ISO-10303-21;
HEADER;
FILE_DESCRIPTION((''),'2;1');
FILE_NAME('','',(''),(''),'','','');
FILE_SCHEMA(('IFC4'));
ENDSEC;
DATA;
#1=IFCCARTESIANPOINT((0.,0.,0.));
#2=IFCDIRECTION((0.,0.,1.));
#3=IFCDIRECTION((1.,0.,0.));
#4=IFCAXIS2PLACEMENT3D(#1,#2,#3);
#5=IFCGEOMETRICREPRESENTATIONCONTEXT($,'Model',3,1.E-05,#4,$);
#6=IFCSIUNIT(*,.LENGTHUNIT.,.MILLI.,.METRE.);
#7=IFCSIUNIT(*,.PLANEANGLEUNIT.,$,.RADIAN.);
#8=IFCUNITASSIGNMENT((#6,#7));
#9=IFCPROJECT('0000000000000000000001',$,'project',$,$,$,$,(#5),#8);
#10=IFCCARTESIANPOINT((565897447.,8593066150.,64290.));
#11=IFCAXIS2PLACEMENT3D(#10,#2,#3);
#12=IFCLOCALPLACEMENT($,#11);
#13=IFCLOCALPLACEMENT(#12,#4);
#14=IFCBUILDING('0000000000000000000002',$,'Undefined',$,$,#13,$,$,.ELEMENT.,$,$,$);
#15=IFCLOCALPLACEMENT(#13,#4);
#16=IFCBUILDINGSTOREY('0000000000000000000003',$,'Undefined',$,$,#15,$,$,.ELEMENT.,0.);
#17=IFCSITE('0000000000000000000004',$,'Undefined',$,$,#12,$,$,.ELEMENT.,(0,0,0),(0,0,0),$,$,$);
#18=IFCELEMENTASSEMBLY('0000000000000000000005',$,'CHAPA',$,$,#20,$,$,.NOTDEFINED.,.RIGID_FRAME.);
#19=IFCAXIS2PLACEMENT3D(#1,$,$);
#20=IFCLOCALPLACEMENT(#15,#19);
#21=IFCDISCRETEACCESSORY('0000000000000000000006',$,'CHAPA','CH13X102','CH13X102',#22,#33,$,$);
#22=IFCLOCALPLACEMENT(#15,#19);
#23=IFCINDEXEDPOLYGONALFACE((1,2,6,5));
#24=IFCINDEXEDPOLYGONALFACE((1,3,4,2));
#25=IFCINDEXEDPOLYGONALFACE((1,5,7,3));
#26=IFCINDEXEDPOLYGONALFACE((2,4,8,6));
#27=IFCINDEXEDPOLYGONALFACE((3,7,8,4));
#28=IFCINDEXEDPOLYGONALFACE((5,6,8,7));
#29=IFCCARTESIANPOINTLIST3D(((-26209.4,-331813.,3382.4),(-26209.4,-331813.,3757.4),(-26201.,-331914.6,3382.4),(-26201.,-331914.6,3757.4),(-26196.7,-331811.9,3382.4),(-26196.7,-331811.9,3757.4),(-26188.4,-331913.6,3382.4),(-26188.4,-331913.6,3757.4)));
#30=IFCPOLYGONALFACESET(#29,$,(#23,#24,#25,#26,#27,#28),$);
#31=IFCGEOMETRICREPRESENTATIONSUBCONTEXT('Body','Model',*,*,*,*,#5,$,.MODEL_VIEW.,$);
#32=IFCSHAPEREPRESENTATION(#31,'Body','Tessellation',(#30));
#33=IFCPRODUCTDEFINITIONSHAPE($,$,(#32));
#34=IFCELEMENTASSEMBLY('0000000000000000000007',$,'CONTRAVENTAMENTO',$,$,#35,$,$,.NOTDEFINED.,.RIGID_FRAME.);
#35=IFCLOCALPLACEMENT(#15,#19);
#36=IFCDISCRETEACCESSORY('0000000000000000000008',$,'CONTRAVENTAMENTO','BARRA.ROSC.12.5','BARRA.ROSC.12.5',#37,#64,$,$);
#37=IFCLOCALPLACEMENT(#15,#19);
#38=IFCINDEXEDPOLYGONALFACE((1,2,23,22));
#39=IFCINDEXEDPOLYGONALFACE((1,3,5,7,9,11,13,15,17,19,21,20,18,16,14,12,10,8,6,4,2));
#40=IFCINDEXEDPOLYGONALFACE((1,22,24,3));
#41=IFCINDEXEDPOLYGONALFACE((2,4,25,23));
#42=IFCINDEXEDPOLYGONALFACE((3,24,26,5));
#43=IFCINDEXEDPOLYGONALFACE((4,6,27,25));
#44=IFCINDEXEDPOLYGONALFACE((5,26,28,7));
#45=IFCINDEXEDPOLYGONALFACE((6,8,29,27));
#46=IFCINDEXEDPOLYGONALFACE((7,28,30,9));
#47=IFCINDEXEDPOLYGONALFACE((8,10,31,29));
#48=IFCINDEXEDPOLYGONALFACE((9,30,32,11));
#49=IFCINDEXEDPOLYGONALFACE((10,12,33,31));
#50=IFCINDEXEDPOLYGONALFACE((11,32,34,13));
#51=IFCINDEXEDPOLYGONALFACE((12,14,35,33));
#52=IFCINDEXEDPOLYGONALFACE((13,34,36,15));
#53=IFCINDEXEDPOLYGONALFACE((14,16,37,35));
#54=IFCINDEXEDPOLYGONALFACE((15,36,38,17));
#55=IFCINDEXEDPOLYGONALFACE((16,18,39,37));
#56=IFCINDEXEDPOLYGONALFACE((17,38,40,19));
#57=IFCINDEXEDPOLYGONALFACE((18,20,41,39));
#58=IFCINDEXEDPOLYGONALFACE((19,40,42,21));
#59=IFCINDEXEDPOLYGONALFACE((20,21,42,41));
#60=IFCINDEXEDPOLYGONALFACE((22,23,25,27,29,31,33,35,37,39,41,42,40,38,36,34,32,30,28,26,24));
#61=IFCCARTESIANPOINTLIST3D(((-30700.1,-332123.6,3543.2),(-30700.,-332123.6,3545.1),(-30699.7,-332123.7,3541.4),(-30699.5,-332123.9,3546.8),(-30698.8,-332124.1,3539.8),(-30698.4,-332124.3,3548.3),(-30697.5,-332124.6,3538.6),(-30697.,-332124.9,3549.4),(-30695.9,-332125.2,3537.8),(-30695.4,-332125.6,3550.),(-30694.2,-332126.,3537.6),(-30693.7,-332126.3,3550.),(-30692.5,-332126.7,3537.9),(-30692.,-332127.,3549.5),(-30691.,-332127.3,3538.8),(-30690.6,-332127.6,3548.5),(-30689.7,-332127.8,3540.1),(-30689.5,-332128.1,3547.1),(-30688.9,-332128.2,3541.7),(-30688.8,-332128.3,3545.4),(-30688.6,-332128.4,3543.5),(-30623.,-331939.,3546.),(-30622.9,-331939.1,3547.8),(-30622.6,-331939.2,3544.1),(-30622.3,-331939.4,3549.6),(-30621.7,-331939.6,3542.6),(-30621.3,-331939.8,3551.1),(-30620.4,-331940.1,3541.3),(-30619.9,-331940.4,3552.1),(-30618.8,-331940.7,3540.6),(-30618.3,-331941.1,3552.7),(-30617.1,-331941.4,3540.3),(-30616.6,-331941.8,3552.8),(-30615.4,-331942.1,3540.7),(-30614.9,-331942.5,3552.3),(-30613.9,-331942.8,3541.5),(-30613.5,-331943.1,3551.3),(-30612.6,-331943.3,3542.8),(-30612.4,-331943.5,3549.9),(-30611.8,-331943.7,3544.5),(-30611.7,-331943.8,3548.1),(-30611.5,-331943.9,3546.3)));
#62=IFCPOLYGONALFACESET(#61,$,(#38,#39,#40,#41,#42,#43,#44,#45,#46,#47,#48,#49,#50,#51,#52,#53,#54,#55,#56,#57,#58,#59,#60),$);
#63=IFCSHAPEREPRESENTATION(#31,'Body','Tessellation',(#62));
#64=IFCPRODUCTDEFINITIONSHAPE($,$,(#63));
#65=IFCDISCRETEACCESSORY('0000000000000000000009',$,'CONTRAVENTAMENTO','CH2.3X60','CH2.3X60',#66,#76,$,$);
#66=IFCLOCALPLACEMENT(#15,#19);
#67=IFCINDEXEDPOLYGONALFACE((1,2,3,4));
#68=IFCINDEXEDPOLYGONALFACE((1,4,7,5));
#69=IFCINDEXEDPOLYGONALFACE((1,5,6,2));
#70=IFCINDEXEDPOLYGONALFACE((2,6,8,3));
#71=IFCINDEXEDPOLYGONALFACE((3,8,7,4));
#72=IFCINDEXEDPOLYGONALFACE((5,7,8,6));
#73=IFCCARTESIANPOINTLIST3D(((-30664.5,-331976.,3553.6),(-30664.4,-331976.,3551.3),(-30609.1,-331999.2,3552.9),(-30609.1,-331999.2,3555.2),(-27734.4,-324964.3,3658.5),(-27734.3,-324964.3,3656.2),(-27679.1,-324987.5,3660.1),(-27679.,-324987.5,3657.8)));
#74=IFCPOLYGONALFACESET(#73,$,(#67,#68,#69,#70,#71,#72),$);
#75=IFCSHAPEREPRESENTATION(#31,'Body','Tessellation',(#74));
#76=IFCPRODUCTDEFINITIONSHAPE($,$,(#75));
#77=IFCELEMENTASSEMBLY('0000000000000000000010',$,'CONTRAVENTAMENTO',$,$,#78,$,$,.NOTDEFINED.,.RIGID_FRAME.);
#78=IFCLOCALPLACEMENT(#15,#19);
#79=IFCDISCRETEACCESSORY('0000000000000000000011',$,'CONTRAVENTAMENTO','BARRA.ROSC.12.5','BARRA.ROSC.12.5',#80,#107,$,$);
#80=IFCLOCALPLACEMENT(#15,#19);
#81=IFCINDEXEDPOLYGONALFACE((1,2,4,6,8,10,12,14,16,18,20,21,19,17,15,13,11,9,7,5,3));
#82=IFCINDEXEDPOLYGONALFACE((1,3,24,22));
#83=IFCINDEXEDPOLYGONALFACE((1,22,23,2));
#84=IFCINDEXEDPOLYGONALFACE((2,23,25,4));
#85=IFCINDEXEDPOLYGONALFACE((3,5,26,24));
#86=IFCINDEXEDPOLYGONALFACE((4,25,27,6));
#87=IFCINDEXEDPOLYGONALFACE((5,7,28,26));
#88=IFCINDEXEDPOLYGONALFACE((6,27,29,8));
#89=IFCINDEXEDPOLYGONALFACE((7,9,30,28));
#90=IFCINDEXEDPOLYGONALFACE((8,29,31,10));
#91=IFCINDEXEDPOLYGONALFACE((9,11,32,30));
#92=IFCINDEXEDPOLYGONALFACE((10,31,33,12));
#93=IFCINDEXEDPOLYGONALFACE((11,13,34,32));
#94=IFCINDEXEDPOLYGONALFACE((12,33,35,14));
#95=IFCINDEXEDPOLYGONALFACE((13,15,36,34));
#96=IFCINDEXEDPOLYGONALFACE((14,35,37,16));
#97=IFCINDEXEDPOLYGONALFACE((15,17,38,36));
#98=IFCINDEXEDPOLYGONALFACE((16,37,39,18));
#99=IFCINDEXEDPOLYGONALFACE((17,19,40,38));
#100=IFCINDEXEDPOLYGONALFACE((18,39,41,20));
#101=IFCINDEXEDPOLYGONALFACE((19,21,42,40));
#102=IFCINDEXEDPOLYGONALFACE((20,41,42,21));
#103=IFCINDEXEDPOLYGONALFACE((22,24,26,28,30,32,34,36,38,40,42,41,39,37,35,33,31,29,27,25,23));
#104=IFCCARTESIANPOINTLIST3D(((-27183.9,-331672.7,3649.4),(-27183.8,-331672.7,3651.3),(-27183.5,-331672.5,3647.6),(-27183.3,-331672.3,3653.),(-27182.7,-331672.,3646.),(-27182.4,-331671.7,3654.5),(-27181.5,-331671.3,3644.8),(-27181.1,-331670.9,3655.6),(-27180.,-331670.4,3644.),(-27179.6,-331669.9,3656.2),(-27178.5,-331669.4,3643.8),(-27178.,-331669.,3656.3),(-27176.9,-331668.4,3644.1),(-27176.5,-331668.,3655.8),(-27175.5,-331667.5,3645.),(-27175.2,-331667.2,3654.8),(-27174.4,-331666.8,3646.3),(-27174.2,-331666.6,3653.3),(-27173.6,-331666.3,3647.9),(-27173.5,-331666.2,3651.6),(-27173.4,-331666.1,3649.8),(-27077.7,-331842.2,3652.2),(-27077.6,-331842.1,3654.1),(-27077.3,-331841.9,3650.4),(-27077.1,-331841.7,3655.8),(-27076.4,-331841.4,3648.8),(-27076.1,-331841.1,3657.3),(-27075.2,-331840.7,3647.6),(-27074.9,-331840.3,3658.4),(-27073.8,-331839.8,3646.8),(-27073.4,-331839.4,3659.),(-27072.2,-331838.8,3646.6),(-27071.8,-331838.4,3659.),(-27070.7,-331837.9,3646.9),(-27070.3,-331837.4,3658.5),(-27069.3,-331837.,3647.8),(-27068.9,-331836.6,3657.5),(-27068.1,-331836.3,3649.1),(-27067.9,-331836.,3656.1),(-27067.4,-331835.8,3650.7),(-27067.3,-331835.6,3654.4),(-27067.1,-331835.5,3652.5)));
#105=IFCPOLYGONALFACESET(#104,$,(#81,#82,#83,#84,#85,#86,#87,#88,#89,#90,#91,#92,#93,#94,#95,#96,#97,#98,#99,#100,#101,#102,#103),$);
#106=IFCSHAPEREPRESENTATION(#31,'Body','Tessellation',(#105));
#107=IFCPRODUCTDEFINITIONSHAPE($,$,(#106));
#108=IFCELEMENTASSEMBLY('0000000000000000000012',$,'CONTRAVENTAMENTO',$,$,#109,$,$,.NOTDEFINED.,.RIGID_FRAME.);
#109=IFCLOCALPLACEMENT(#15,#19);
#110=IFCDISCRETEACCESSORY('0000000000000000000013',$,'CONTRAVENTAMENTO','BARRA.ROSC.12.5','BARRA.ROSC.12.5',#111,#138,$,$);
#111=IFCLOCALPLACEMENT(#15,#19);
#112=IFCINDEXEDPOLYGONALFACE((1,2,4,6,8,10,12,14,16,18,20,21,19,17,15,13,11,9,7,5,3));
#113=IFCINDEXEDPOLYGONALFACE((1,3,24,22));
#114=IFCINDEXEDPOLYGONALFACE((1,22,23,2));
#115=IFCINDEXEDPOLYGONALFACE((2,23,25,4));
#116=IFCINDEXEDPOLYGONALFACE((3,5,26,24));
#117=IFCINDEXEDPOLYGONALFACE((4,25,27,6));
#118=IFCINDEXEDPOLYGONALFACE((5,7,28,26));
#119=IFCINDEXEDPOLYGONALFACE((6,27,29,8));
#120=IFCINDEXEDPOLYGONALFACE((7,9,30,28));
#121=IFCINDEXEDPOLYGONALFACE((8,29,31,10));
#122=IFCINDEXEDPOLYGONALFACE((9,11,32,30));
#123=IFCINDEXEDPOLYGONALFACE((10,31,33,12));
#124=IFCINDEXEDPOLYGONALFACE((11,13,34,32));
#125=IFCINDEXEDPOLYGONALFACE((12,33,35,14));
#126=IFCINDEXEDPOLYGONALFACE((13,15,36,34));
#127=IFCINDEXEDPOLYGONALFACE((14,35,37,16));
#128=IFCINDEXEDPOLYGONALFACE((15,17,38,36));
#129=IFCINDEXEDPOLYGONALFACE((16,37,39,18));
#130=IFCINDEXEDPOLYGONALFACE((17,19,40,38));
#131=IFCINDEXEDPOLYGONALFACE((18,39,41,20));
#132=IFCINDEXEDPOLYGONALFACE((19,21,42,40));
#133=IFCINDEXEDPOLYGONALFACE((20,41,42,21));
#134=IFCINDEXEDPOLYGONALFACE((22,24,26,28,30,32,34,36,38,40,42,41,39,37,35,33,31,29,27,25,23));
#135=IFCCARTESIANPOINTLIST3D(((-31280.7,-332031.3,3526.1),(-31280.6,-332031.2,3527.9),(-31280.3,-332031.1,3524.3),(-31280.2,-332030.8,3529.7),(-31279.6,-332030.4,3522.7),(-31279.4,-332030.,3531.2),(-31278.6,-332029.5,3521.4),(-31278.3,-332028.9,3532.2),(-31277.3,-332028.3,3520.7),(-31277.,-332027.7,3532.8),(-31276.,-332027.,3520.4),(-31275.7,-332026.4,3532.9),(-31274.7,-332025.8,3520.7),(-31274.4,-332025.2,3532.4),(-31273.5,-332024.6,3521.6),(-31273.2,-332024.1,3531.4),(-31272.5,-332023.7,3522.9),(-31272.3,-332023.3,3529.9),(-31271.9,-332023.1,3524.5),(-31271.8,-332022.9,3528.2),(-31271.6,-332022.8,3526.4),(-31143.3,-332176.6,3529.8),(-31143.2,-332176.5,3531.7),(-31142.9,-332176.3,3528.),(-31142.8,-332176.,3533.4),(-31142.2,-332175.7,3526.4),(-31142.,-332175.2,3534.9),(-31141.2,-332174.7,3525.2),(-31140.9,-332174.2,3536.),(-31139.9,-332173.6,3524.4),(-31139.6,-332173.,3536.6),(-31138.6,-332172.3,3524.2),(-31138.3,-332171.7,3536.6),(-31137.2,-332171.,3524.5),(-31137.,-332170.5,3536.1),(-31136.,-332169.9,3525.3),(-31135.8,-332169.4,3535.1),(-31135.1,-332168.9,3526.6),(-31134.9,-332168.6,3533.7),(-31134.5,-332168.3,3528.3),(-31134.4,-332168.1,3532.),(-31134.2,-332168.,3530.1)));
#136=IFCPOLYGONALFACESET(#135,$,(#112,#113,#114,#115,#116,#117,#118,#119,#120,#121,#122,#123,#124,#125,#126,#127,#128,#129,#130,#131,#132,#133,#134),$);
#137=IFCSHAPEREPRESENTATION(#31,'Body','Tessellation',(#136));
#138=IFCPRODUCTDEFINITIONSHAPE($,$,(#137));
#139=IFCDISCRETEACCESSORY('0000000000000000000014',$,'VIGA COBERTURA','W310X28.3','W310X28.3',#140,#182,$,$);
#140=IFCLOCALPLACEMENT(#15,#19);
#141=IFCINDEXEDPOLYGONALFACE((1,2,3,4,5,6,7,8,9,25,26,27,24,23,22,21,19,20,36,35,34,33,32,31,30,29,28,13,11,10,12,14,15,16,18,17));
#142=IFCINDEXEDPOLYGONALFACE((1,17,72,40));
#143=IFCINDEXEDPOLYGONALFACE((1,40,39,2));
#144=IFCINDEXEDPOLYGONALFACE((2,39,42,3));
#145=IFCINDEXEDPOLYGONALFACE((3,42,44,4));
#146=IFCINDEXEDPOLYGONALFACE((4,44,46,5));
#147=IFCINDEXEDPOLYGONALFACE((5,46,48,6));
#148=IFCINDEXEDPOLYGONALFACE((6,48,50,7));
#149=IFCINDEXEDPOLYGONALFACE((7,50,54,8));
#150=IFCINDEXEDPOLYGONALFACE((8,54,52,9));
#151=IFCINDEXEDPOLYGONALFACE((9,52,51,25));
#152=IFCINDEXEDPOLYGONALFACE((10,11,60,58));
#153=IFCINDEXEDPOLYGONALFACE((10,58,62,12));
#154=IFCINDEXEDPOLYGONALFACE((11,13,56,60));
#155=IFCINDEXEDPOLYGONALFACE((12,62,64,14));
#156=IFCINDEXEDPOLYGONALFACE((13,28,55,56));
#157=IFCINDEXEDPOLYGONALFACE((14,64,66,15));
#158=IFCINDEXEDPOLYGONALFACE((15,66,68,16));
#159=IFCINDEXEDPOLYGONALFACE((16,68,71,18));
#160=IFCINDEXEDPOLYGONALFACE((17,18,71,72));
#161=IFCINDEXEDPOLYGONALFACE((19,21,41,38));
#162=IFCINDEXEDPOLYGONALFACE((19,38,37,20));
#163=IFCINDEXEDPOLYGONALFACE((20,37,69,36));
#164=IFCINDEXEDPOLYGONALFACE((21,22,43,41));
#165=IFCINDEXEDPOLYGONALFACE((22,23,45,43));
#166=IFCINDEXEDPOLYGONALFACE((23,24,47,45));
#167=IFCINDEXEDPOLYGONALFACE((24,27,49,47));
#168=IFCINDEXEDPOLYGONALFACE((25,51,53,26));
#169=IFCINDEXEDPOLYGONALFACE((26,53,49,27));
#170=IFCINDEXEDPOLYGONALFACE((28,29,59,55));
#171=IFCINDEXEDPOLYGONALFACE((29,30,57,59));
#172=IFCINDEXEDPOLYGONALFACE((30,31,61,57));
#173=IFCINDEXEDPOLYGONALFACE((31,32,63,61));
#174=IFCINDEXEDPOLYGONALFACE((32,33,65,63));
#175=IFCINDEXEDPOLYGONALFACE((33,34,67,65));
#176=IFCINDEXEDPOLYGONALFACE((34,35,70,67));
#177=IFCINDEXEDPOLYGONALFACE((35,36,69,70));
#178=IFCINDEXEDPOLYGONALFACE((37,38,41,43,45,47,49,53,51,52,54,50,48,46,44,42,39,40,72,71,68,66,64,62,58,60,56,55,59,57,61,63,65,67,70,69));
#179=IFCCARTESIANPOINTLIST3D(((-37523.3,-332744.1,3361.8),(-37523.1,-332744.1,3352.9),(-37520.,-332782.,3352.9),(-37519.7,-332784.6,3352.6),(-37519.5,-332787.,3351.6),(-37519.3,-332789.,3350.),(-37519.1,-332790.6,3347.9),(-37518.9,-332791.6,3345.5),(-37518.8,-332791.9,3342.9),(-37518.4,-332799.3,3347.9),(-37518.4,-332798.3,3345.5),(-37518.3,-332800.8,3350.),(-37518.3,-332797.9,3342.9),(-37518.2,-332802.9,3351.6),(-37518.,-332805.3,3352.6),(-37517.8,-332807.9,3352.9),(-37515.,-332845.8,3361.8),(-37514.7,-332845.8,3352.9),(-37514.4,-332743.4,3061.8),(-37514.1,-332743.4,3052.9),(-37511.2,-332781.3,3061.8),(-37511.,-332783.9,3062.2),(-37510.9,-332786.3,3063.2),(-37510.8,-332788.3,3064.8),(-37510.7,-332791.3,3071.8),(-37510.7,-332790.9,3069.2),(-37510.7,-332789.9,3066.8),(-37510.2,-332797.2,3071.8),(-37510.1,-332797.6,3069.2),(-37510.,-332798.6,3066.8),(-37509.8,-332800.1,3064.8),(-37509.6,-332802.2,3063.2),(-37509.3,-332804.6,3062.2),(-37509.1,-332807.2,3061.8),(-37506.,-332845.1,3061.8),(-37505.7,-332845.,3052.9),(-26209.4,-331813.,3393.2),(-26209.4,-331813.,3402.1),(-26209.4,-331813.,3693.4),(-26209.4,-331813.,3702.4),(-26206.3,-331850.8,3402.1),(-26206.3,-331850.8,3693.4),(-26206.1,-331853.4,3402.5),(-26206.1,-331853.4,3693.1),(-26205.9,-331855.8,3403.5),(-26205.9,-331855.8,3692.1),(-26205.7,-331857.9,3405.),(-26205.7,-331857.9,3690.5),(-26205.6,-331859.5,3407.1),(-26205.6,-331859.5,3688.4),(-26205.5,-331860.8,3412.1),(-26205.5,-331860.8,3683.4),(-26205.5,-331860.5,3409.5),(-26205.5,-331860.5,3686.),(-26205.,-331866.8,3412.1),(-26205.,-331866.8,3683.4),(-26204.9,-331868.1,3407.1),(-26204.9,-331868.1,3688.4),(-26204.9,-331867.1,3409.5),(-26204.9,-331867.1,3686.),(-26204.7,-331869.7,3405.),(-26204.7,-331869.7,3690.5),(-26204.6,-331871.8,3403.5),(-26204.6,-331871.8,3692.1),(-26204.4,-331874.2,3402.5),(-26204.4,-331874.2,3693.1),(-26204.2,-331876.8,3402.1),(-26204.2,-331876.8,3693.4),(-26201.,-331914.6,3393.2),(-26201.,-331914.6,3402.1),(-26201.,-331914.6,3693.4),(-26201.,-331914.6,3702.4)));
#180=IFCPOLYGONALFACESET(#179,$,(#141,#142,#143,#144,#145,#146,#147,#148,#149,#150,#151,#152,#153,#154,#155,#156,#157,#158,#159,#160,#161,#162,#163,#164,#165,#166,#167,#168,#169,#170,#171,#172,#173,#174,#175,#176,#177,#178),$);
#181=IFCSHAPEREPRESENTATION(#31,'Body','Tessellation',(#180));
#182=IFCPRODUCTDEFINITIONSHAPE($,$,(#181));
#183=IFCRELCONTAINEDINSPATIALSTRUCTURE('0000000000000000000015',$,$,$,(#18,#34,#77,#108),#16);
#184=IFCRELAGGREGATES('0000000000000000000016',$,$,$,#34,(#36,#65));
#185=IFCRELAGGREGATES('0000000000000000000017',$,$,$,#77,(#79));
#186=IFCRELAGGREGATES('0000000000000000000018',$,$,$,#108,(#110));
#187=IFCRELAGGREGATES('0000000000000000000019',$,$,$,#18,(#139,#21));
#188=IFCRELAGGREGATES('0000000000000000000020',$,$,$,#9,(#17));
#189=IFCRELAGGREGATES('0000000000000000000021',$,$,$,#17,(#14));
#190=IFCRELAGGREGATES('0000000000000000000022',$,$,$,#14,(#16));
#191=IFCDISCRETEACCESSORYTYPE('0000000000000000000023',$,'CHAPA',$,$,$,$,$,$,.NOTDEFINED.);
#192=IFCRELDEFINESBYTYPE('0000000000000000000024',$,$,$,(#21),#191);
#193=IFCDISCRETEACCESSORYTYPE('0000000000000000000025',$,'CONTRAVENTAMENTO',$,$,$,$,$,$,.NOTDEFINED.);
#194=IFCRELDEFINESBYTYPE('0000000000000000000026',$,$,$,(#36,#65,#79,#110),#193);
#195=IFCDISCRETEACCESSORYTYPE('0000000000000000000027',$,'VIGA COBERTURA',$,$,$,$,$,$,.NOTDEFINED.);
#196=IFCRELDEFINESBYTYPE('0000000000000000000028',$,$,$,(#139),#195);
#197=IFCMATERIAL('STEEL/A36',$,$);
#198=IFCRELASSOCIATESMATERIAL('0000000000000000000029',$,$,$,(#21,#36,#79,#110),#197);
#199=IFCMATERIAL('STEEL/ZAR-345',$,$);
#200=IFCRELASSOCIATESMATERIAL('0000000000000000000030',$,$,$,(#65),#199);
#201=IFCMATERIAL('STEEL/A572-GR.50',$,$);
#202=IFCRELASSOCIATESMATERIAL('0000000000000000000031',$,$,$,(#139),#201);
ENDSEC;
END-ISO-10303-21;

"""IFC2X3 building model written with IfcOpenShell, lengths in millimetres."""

from ifc_helpers import new_model, si_unit, frame, origin_with_axes, origin_2d_with_axis, place, context, subcontext, project, spatial, polyline, circle, i_section, outline, extrude, clip, halfspace, material, type_object, element, aggregate, save


model = new_model("IFC2X3")

# Units and contexts
model_context = context("Model", 3, precision=1e-05, world=origin_with_axes())
body_context = subcontext(model_context, "Body", "Model", "MODEL_VIEW")
ifc_project = project(units=[si_unit("LENGTHUNIT", "METRE", prefix="MILLI"), si_unit("PLANEANGLEUNIT", "RADIAN")], contexts=[model_context])

# Site, building, storey
site_placement = place(None, frame((565897447.0, 8593066150.0, 64290.0), z_axis=(0.0, 0.0, 1.0), x_axis=(1.0, 0.0, 0.0)))
site = spatial("IfcSite", under=ifc_project, at=site_placement, Name="Undefined", CompositionType="ELEMENT", RefLatitude=(0, 0, 0), RefLongitude=(0, 0, 0))
building_placement = place(site_placement, origin_with_axes())
building = spatial("IfcBuilding", under=site, at=building_placement, Name="Undefined", CompositionType="ELEMENT")
storey_placement = place(building_placement, origin_with_axes())
storey = spatial("IfcBuildingStorey", under=building, at=storey_placement, Name="Undefined", CompositionType="ELEMENT", Elevation=0.0)

# Shared definitions
ifc_material_1 = material(Name="STEEL/A572-GR.50")

# Shared definitions
ifc_material_2 = material(Name="STEEL/A36")

# Shared definitions
discrete_accessory_type_1 = type_object("IfcDiscreteAccessoryType", Name="CHAPA")

# Element assembly, discrete accessory
assembly_1_placement = place(storey_placement, origin_with_axes())
assembly_1 = element("IfcElementAssembly", 1, at=assembly_1_placement, inside=storey, Name="CHAPA", AssemblyPlace="NOTDEFINED", PredefinedType="RIGID_FRAME")
discrete_accessory_1_placement = place(assembly_1_placement, frame((-26198.9, -331863.3, 3757.4), z_axis=(-0.99663, -0.082025, 0.0), x_axis=(0.0, 0.0, -1.0)))
discrete_accessory_1 = element("IfcDiscreteAccessory", 2, at=discrete_accessory_1_placement, type_object=discrete_accessory_type_1, material=ifc_material_2, Name="CHAPA", Description="CH13X102", ObjectType="CH13X102", context=body_context, shape_type="SweptSolid", body=[
    extrude(outline(polyline([(375.0, -51.0), (0.0, -51.0), (0.0, 51.0), (375.0, 51.0), (375.0, -51.0)])), frame((0.0, 0.0, -6.3), z_axis=(0.0, 0.0, 1.0), x_axis=(1.0, 0.0, 0.0)), (0.0, 0.0, 1.0), 12.7),
])

# Element assembly, discrete accessories
assembly_2_placement = place(storey_placement, origin_with_axes())
assembly_2 = element("IfcElementAssembly", 3, at=assembly_2_placement, inside=storey, Name="CONTRAVENTAMENTO", AssemblyPlace="NOTDEFINED", PredefinedType="RIGID_FRAME")
discrete_accessory_type_2 = type_object("IfcDiscreteAccessoryType", Name="CONTRAVENTAMENTO")
discrete_accessory_2_placement = place(assembly_2_placement, frame((-30694.4, -332126.0, 3543.8), z_axis=(0.922203, -0.385776, 0.026799), x_axis=(0.385536, 0.92259, 0.013797)))
discrete_accessory_2 = element("IfcDiscreteAccessory", 4, at=discrete_accessory_2_placement, type_object=discrete_accessory_type_2, material=ifc_material_2, Name="CONTRAVENTAMENTO", Description="BARRA.ROSC.12.5", ObjectType="BARRA.ROSC.12.5", context=body_context, shape_type="SweptSolid", body=[
    extrude(circle(Radius=6.2, at=origin_2d_with_axis()), frame((200.0, 0.0, 0.0), z_axis=(-1.0, 0.0, 0.0), x_axis=(0.0, -1.0, 0.0)), (0.0, 0.0, 1.0), 200.0),
])
ifc_material_3 = material(Name="STEEL/ZAR-345")
discrete_accessory_3_placement = place(assembly_2_placement, frame((-30636.8, -331987.6, 3553.3), z_axis=(0.030047, 0.002392, -0.999546), x_axis=(0.385536, 0.92259, 0.013797)))
discrete_accessory_3 = element("IfcDiscreteAccessory", 5, at=discrete_accessory_3_placement, type_object=discrete_accessory_type_2, material=ifc_material_3, Name="CONTRAVENTAMENTO", Description="CH2.3X60", ObjectType="CH2.3X60", context=body_context, shape_type="SweptSolid", body=[
    extrude(outline(polyline([(7600.0, -30.0), (0.0, -30.0), (0.0, 30.0), (7600.0, 30.0), (7600.0, -30.0)])), frame((0.0, 0.0, -1.1), z_axis=(0.0, 0.0, 1.0), x_axis=(1.0, 0.0, 0.0)), (0.0, 0.0, 1.0), 2.3),
])
aggregate(assembly_2, [discrete_accessory_2, discrete_accessory_3])

# Element assemblies, discrete accessories
assembly_3_placement = place(storey_placement, origin_with_axes())
assembly_3 = element("IfcElementAssembly", 6, at=assembly_3_placement, inside=storey, Name="CONTRAVENTAMENTO", AssemblyPlace="NOTDEFINED", PredefinedType="RIGID_FRAME")
discrete_accessory_4_placement = place(assembly_3_placement, frame((-27072.4, -331838.9, 3652.8), z_axis=(0.84672, 0.531363, 0.026799), x_axis=(-0.53119, 0.84714, -0.013797)))
discrete_accessory_4 = element("IfcDiscreteAccessory", 7, at=discrete_accessory_4_placement, type_object=discrete_accessory_type_2, material=ifc_material_2, Name="CONTRAVENTAMENTO", Description="BARRA.ROSC.12.5", ObjectType="BARRA.ROSC.12.5", context=body_context, shape_type="SweptSolid", body=[
    extrude(circle(Radius=6.2, at=origin_2d_with_axis()), frame((200.0, 0.0, 0.0), z_axis=(-1.0, 0.0, 0.0), x_axis=(0.0, -1.0, 0.0)), (0.0, 0.0, 1.0), 200.0),
])
aggregate(assembly_3, [discrete_accessory_4])
assembly_4_placement = place(storey_placement, origin_with_axes())
assembly_4 = element("IfcElementAssembly", 8, at=assembly_4_placement, inside=storey, Name="CONTRAVENTAMENTO", AssemblyPlace="NOTDEFINED", PredefinedType="RIGID_FRAME")
discrete_accessory_5_placement = place(assembly_4_placement, frame((-31138.8, -332172.3, 3530.4), z_axis=(0.725882, 0.687412, 0.023679), x_axis=(-0.687161, 0.726263, -0.018758)))
discrete_accessory_5 = element("IfcDiscreteAccessory", 9, at=discrete_accessory_5_placement, type_object=discrete_accessory_type_2, material=ifc_material_2, Name="CONTRAVENTAMENTO", Description="BARRA.ROSC.12.5", ObjectType="BARRA.ROSC.12.5", context=body_context, shape_type="SweptSolid", body=[
    extrude(circle(Radius=6.2, at=origin_2d_with_axis()), frame((200.0, 0.0, 0.0), z_axis=(-1.0, 0.0, 0.0), x_axis=(0.0, -1.0, 0.0)), (0.0, 0.0, 1.0), 200.0),
])
aggregate(assembly_4, [discrete_accessory_5])

# Discrete accessory
discrete_accessory_type_3 = type_object("IfcDiscreteAccessoryType", Name="VIGA COBERTURA")
discrete_accessory_6_placement = place(assembly_1_placement, frame((-26187.9, -331862.4, 3548.3), z_axis=(0.029885, 0.00246, -0.99955), x_axis=(-0.996182, -0.081989, -0.029987)))
discrete_accessory_6 = element("IfcDiscreteAccessory", 10, at=discrete_accessory_6_placement, type_object=discrete_accessory_type_3, material=ifc_material_1, Name="VIGA COBERTURA", Description="W310X28.3", ObjectType="W310X28.3", context=body_context, shape_type="Clipping", body=[
    clip(extrude(i_section(OverallWidth=102.0, OverallDepth=309.0, WebThickness=6.0, FlangeThickness=8.9, FilletRadius=10.0, at=origin_2d_with_axis()), frame((11370.0, 0.0, 0.0), z_axis=(-1.0, 0.0, 0.0), x_axis=(0.0, -1.0, 0.0)), (0.0, 0.0, 1.0), 11370.0), halfspace(frame((12.7, -51.0, -154.5), z_axis=(-0.99955, 0.0, 0.029987), x_axis=(0.0, 1.0, 0.0)), False)),
])
aggregate(assembly_1, [discrete_accessory_6, discrete_accessory_1])

save(model, "model.ifc")
